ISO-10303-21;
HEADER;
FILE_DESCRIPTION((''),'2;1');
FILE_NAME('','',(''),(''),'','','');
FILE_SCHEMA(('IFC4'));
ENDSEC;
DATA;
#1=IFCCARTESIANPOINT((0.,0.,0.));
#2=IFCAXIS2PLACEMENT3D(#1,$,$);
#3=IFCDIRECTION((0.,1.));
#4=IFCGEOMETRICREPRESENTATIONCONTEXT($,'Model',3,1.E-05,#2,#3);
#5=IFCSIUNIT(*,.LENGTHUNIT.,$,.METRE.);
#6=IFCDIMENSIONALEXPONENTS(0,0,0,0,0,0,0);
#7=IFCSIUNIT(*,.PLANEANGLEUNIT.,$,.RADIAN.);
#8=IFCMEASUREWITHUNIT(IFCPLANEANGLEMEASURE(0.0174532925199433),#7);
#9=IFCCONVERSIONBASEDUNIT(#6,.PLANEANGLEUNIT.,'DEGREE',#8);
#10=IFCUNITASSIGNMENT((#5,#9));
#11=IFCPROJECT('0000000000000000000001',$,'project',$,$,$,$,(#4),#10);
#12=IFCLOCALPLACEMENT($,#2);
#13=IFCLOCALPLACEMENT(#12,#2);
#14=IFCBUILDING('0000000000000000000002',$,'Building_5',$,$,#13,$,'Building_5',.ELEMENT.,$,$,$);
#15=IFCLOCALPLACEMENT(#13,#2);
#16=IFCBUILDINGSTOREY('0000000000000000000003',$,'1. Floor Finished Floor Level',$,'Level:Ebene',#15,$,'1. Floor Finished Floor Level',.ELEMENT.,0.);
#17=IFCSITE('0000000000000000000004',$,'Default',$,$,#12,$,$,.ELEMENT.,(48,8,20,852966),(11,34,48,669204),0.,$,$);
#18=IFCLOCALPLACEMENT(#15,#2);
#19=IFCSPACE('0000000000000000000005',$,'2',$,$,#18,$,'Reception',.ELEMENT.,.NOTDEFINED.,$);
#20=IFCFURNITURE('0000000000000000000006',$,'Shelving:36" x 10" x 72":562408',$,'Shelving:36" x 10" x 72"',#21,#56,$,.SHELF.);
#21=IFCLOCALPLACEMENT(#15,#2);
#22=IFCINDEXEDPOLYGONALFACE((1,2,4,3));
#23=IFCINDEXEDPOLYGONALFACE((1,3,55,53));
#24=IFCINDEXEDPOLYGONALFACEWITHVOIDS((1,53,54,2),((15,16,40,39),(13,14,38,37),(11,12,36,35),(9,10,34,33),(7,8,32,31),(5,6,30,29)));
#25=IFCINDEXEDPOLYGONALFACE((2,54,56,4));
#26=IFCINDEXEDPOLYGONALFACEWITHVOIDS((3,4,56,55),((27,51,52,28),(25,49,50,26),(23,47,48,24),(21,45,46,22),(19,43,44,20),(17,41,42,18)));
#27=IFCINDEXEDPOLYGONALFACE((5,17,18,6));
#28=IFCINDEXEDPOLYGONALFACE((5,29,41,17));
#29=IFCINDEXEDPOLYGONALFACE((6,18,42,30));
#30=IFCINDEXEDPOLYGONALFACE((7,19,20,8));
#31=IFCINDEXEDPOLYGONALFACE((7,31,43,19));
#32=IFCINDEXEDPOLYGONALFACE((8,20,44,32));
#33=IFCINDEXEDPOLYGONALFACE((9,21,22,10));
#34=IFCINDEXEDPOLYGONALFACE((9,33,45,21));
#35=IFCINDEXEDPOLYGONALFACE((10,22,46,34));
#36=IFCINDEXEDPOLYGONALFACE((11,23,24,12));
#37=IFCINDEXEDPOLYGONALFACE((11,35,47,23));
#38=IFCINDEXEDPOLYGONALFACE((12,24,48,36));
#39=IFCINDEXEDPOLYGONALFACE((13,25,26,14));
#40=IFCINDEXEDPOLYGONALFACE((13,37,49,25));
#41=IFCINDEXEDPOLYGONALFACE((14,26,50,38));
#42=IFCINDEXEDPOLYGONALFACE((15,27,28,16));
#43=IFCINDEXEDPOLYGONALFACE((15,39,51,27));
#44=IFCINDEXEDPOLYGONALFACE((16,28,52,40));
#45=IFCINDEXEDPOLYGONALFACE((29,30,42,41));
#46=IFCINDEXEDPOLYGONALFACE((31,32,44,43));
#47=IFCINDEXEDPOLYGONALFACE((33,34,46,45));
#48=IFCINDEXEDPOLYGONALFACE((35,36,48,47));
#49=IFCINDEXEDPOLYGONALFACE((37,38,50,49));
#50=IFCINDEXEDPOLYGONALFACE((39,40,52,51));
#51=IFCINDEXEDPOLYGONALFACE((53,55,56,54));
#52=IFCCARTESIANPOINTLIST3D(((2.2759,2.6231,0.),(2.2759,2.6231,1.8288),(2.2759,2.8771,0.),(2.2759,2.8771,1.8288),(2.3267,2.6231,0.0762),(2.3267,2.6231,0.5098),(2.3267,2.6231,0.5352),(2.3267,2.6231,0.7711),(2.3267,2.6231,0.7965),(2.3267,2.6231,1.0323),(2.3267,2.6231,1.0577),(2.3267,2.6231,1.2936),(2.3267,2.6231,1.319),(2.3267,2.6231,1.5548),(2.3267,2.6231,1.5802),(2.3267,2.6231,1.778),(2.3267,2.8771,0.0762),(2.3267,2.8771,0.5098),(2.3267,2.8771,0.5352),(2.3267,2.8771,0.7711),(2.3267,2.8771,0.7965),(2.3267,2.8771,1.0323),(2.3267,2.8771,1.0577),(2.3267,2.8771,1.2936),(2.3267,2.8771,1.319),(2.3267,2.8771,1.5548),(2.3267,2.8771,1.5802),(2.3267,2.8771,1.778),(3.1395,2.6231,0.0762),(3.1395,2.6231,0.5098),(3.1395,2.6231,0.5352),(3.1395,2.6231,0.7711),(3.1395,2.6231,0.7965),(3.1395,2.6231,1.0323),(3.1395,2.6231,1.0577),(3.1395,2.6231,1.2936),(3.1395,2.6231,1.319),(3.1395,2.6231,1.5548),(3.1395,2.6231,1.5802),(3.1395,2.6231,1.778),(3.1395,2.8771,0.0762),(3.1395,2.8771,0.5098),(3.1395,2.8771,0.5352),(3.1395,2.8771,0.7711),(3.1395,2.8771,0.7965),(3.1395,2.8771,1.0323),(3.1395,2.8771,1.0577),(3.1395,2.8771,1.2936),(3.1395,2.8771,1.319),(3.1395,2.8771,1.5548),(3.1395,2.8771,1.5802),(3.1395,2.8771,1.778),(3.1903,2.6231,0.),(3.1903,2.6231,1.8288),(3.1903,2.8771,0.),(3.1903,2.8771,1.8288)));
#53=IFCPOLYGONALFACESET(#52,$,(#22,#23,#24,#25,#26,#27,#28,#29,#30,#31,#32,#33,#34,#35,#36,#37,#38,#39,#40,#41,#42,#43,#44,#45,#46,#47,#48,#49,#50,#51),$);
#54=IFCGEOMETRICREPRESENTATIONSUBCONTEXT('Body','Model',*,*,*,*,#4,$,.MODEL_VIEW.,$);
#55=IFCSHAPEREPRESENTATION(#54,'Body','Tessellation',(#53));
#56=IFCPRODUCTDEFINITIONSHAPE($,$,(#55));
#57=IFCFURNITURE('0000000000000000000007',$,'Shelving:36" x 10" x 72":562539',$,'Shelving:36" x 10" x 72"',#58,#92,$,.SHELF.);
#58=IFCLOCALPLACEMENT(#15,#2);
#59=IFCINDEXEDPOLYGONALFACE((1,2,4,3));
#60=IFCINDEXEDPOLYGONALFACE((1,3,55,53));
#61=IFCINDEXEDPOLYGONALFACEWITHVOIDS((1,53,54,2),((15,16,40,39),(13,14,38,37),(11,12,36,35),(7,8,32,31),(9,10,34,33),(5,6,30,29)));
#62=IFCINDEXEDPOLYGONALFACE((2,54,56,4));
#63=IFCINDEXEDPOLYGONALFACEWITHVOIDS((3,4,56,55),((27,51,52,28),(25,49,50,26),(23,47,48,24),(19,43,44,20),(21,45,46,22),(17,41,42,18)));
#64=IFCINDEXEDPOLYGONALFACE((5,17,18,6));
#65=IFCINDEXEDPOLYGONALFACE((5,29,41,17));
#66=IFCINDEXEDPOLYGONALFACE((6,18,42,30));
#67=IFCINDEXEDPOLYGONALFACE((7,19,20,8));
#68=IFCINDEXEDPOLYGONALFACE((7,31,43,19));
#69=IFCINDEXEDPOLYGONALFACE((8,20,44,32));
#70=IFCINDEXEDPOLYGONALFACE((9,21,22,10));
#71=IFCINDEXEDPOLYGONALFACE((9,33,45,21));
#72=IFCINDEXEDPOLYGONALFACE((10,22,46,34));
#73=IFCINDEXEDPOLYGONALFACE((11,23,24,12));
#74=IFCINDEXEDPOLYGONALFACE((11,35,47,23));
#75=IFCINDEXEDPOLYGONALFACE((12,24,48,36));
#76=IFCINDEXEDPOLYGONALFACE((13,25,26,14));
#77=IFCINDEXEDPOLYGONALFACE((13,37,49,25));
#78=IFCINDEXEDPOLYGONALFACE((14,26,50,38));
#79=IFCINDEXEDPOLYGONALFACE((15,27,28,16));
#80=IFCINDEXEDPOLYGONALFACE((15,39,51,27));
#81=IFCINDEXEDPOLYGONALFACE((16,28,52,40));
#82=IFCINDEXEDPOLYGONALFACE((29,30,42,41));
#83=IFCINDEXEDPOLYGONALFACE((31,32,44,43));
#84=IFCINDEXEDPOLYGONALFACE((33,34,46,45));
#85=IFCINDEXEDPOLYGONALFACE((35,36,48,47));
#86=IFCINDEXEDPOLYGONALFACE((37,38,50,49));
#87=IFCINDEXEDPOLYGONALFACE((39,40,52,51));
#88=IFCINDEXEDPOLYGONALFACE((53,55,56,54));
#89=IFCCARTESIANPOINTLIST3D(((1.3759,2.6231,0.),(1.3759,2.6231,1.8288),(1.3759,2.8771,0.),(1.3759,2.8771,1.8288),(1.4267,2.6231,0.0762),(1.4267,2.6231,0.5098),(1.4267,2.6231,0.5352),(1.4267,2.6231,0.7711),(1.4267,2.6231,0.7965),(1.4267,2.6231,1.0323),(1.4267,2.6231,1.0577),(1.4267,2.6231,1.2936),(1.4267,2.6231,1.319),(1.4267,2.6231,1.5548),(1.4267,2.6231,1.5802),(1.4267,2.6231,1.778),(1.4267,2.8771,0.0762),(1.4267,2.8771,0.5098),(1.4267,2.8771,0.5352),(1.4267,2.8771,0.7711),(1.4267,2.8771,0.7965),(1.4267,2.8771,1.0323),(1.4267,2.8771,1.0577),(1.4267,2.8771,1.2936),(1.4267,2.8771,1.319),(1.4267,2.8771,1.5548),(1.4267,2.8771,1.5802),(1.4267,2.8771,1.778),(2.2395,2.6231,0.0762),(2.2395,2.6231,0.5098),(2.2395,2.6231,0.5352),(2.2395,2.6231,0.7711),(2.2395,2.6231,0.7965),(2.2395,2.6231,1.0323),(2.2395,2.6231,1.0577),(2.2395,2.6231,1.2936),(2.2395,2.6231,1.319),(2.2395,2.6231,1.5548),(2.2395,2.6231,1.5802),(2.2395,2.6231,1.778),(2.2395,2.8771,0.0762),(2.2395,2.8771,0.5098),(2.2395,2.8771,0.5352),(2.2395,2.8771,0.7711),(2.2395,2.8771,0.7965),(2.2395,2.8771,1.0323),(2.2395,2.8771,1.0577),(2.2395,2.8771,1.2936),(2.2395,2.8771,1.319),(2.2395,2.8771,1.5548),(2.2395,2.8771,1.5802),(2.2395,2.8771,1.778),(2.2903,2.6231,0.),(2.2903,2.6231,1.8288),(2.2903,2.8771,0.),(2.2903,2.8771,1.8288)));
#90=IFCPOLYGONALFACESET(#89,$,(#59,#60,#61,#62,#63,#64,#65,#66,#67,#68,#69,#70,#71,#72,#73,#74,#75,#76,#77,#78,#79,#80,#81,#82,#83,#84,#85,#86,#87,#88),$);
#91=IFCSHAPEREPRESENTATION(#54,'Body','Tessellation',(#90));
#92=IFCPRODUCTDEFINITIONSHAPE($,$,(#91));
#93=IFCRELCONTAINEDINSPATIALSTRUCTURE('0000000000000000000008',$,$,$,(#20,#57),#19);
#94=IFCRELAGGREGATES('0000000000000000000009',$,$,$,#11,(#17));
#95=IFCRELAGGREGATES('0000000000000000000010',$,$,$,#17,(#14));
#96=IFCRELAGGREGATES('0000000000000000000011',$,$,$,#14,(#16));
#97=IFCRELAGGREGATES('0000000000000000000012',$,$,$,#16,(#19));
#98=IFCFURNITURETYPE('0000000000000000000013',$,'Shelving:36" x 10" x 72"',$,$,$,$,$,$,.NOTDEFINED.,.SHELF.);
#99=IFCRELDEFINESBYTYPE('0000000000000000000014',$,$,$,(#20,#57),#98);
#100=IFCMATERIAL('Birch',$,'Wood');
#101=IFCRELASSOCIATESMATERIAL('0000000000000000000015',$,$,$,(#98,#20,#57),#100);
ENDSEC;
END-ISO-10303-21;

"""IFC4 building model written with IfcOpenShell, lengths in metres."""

from ifc_helpers import new_model, entity, si_unit, converted_unit, direction, frame, origin, place, context, subcontext, project, spatial, indexed_curve, outline, extrude, source, transform, mapped, material, type_object, type_shapes, element, save


model = new_model("IFC4")

# Units and contexts
model_context = context("Model", 3, precision=1e-05, world=origin(), true_north=direction((0.0, 1.0)))
body_context = subcontext(model_context, "Body", "Model", "MODEL_VIEW")
ifc_project = project(units=[si_unit("LENGTHUNIT", "METRE"), converted_unit("PLANEANGLEUNIT", "DEGREE", entity("IfcPlaneAngleMeasure", 0.0174532925199433), si_unit("PLANEANGLEUNIT", "RADIAN"), dimensions=[0, 0, 0, 0, 0, 0, 0])], contexts=[model_context])

# Site, building, storey
site_placement = place(None, origin())
site = spatial("IfcSite", under=ifc_project, at=site_placement, Name="Default", CompositionType="ELEMENT", RefLatitude=(48, 8, 20, 852966), RefLongitude=(11, 34, 48, 669204), RefElevation=0.0)
building_placement = place(site_placement, origin())
building = spatial("IfcBuilding", under=site, at=building_placement, Name="Building_5", LongName="Building_5", CompositionType="ELEMENT")
storey_placement = place(building_placement, origin())
storey = spatial("IfcBuildingStorey", under=building, at=storey_placement, Name="1. Floor Finished Floor Level", ObjectType="Level:Ebene", LongName="1. Floor Finished Floor Level", CompositionType="ELEMENT", Elevation=0.0)

# Shared definitions
space_placement = place(storey_placement, origin())
space = spatial("IfcSpace", under=storey, at=space_placement, Name="2", LongName="Reception", CompositionType="ELEMENT", PredefinedType="NOTDEFINED")

# Furniture
ifc_material_1 = material(Name="Birch", Category="Wood")
furniture_type = type_object("IfcFurnitureType", Name="Shelving:36\" x 10\" x 72\"", AssemblyPlace="NOTDEFINED", PredefinedType="SHELF", material=ifc_material_1)
shared_shape_1 = source(origin(), body_context, "Body", "SweptSolid", [
    extrude(outline(indexed_curve([(-0.4572, -0.9144), (0.4572, -0.9144), (0.4572, 0.9144), (-0.4572, 0.9144), (-0.4572, -0.9144)], self_intersect=False), holes=[indexed_curve([(-0.4064, 0.8636), (0.4064, 0.8636), (0.4064, 0.6658), (-0.4064, 0.6658), (-0.4064, 0.8636)], self_intersect=False), indexed_curve([(-0.4064, -0.8382), (-0.4064, -0.4046), (0.4064, -0.4046), (0.4064, -0.8382), (-0.4064, -0.8382)], self_intersect=False), indexed_curve([(0.4064, 0.1433), (-0.4064, 0.1433), (-0.4064, 0.3792), (0.4064, 0.3792), (0.4064, 0.1433)], self_intersect=False), indexed_curve([(-0.4064, 0.6404), (0.4064, 0.6404), (0.4064, 0.4046), (-0.4064, 0.4046), (-0.4064, 0.6404)], self_intersect=False), indexed_curve([(-0.4064, 0.1179), (0.4064, 0.1179), (0.4064, -0.1179), (-0.4064, -0.1179), (-0.4064, 0.1179)], self_intersect=False), indexed_curve([(-0.4064, -0.1433), (0.4064, -0.1433), (0.4064, -0.3792), (-0.4064, -0.3792), (-0.4064, -0.1433)], self_intersect=False)]), frame((0.0, -0.4318, 0.9144), z_axis=(0.0, 1.0, 0.0), x_axis=(-1.0, 0.0, 0.0)), (0.0, 0.0, 1.0), 0.254),
])
type_shapes(furniture_type, [shared_shape_1])
for number, where, name in (
    (1, (2.7331, 3.0549, 0.0), "Shelving:36\" x 10\" x 72\":562408"),
    (2, (1.8331, 3.0549, 0.0), "Shelving:36\" x 10\" x 72\":562539"),
):
    element("IfcFurniture", number, at=place(space_placement, frame(where)), inside=space, type_object=furniture_type, material=ifc_material_1, Name=name, ObjectType="Shelving:36\" x 10\" x 72\"", PredefinedType="SHELF", context=body_context, shape_type="MappedRepresentation", body=[
        mapped(shared_shape_1, transform((0.0, 0.0, 0.0), scale=1.0)),
    ])

save(model, "model.ifc")
